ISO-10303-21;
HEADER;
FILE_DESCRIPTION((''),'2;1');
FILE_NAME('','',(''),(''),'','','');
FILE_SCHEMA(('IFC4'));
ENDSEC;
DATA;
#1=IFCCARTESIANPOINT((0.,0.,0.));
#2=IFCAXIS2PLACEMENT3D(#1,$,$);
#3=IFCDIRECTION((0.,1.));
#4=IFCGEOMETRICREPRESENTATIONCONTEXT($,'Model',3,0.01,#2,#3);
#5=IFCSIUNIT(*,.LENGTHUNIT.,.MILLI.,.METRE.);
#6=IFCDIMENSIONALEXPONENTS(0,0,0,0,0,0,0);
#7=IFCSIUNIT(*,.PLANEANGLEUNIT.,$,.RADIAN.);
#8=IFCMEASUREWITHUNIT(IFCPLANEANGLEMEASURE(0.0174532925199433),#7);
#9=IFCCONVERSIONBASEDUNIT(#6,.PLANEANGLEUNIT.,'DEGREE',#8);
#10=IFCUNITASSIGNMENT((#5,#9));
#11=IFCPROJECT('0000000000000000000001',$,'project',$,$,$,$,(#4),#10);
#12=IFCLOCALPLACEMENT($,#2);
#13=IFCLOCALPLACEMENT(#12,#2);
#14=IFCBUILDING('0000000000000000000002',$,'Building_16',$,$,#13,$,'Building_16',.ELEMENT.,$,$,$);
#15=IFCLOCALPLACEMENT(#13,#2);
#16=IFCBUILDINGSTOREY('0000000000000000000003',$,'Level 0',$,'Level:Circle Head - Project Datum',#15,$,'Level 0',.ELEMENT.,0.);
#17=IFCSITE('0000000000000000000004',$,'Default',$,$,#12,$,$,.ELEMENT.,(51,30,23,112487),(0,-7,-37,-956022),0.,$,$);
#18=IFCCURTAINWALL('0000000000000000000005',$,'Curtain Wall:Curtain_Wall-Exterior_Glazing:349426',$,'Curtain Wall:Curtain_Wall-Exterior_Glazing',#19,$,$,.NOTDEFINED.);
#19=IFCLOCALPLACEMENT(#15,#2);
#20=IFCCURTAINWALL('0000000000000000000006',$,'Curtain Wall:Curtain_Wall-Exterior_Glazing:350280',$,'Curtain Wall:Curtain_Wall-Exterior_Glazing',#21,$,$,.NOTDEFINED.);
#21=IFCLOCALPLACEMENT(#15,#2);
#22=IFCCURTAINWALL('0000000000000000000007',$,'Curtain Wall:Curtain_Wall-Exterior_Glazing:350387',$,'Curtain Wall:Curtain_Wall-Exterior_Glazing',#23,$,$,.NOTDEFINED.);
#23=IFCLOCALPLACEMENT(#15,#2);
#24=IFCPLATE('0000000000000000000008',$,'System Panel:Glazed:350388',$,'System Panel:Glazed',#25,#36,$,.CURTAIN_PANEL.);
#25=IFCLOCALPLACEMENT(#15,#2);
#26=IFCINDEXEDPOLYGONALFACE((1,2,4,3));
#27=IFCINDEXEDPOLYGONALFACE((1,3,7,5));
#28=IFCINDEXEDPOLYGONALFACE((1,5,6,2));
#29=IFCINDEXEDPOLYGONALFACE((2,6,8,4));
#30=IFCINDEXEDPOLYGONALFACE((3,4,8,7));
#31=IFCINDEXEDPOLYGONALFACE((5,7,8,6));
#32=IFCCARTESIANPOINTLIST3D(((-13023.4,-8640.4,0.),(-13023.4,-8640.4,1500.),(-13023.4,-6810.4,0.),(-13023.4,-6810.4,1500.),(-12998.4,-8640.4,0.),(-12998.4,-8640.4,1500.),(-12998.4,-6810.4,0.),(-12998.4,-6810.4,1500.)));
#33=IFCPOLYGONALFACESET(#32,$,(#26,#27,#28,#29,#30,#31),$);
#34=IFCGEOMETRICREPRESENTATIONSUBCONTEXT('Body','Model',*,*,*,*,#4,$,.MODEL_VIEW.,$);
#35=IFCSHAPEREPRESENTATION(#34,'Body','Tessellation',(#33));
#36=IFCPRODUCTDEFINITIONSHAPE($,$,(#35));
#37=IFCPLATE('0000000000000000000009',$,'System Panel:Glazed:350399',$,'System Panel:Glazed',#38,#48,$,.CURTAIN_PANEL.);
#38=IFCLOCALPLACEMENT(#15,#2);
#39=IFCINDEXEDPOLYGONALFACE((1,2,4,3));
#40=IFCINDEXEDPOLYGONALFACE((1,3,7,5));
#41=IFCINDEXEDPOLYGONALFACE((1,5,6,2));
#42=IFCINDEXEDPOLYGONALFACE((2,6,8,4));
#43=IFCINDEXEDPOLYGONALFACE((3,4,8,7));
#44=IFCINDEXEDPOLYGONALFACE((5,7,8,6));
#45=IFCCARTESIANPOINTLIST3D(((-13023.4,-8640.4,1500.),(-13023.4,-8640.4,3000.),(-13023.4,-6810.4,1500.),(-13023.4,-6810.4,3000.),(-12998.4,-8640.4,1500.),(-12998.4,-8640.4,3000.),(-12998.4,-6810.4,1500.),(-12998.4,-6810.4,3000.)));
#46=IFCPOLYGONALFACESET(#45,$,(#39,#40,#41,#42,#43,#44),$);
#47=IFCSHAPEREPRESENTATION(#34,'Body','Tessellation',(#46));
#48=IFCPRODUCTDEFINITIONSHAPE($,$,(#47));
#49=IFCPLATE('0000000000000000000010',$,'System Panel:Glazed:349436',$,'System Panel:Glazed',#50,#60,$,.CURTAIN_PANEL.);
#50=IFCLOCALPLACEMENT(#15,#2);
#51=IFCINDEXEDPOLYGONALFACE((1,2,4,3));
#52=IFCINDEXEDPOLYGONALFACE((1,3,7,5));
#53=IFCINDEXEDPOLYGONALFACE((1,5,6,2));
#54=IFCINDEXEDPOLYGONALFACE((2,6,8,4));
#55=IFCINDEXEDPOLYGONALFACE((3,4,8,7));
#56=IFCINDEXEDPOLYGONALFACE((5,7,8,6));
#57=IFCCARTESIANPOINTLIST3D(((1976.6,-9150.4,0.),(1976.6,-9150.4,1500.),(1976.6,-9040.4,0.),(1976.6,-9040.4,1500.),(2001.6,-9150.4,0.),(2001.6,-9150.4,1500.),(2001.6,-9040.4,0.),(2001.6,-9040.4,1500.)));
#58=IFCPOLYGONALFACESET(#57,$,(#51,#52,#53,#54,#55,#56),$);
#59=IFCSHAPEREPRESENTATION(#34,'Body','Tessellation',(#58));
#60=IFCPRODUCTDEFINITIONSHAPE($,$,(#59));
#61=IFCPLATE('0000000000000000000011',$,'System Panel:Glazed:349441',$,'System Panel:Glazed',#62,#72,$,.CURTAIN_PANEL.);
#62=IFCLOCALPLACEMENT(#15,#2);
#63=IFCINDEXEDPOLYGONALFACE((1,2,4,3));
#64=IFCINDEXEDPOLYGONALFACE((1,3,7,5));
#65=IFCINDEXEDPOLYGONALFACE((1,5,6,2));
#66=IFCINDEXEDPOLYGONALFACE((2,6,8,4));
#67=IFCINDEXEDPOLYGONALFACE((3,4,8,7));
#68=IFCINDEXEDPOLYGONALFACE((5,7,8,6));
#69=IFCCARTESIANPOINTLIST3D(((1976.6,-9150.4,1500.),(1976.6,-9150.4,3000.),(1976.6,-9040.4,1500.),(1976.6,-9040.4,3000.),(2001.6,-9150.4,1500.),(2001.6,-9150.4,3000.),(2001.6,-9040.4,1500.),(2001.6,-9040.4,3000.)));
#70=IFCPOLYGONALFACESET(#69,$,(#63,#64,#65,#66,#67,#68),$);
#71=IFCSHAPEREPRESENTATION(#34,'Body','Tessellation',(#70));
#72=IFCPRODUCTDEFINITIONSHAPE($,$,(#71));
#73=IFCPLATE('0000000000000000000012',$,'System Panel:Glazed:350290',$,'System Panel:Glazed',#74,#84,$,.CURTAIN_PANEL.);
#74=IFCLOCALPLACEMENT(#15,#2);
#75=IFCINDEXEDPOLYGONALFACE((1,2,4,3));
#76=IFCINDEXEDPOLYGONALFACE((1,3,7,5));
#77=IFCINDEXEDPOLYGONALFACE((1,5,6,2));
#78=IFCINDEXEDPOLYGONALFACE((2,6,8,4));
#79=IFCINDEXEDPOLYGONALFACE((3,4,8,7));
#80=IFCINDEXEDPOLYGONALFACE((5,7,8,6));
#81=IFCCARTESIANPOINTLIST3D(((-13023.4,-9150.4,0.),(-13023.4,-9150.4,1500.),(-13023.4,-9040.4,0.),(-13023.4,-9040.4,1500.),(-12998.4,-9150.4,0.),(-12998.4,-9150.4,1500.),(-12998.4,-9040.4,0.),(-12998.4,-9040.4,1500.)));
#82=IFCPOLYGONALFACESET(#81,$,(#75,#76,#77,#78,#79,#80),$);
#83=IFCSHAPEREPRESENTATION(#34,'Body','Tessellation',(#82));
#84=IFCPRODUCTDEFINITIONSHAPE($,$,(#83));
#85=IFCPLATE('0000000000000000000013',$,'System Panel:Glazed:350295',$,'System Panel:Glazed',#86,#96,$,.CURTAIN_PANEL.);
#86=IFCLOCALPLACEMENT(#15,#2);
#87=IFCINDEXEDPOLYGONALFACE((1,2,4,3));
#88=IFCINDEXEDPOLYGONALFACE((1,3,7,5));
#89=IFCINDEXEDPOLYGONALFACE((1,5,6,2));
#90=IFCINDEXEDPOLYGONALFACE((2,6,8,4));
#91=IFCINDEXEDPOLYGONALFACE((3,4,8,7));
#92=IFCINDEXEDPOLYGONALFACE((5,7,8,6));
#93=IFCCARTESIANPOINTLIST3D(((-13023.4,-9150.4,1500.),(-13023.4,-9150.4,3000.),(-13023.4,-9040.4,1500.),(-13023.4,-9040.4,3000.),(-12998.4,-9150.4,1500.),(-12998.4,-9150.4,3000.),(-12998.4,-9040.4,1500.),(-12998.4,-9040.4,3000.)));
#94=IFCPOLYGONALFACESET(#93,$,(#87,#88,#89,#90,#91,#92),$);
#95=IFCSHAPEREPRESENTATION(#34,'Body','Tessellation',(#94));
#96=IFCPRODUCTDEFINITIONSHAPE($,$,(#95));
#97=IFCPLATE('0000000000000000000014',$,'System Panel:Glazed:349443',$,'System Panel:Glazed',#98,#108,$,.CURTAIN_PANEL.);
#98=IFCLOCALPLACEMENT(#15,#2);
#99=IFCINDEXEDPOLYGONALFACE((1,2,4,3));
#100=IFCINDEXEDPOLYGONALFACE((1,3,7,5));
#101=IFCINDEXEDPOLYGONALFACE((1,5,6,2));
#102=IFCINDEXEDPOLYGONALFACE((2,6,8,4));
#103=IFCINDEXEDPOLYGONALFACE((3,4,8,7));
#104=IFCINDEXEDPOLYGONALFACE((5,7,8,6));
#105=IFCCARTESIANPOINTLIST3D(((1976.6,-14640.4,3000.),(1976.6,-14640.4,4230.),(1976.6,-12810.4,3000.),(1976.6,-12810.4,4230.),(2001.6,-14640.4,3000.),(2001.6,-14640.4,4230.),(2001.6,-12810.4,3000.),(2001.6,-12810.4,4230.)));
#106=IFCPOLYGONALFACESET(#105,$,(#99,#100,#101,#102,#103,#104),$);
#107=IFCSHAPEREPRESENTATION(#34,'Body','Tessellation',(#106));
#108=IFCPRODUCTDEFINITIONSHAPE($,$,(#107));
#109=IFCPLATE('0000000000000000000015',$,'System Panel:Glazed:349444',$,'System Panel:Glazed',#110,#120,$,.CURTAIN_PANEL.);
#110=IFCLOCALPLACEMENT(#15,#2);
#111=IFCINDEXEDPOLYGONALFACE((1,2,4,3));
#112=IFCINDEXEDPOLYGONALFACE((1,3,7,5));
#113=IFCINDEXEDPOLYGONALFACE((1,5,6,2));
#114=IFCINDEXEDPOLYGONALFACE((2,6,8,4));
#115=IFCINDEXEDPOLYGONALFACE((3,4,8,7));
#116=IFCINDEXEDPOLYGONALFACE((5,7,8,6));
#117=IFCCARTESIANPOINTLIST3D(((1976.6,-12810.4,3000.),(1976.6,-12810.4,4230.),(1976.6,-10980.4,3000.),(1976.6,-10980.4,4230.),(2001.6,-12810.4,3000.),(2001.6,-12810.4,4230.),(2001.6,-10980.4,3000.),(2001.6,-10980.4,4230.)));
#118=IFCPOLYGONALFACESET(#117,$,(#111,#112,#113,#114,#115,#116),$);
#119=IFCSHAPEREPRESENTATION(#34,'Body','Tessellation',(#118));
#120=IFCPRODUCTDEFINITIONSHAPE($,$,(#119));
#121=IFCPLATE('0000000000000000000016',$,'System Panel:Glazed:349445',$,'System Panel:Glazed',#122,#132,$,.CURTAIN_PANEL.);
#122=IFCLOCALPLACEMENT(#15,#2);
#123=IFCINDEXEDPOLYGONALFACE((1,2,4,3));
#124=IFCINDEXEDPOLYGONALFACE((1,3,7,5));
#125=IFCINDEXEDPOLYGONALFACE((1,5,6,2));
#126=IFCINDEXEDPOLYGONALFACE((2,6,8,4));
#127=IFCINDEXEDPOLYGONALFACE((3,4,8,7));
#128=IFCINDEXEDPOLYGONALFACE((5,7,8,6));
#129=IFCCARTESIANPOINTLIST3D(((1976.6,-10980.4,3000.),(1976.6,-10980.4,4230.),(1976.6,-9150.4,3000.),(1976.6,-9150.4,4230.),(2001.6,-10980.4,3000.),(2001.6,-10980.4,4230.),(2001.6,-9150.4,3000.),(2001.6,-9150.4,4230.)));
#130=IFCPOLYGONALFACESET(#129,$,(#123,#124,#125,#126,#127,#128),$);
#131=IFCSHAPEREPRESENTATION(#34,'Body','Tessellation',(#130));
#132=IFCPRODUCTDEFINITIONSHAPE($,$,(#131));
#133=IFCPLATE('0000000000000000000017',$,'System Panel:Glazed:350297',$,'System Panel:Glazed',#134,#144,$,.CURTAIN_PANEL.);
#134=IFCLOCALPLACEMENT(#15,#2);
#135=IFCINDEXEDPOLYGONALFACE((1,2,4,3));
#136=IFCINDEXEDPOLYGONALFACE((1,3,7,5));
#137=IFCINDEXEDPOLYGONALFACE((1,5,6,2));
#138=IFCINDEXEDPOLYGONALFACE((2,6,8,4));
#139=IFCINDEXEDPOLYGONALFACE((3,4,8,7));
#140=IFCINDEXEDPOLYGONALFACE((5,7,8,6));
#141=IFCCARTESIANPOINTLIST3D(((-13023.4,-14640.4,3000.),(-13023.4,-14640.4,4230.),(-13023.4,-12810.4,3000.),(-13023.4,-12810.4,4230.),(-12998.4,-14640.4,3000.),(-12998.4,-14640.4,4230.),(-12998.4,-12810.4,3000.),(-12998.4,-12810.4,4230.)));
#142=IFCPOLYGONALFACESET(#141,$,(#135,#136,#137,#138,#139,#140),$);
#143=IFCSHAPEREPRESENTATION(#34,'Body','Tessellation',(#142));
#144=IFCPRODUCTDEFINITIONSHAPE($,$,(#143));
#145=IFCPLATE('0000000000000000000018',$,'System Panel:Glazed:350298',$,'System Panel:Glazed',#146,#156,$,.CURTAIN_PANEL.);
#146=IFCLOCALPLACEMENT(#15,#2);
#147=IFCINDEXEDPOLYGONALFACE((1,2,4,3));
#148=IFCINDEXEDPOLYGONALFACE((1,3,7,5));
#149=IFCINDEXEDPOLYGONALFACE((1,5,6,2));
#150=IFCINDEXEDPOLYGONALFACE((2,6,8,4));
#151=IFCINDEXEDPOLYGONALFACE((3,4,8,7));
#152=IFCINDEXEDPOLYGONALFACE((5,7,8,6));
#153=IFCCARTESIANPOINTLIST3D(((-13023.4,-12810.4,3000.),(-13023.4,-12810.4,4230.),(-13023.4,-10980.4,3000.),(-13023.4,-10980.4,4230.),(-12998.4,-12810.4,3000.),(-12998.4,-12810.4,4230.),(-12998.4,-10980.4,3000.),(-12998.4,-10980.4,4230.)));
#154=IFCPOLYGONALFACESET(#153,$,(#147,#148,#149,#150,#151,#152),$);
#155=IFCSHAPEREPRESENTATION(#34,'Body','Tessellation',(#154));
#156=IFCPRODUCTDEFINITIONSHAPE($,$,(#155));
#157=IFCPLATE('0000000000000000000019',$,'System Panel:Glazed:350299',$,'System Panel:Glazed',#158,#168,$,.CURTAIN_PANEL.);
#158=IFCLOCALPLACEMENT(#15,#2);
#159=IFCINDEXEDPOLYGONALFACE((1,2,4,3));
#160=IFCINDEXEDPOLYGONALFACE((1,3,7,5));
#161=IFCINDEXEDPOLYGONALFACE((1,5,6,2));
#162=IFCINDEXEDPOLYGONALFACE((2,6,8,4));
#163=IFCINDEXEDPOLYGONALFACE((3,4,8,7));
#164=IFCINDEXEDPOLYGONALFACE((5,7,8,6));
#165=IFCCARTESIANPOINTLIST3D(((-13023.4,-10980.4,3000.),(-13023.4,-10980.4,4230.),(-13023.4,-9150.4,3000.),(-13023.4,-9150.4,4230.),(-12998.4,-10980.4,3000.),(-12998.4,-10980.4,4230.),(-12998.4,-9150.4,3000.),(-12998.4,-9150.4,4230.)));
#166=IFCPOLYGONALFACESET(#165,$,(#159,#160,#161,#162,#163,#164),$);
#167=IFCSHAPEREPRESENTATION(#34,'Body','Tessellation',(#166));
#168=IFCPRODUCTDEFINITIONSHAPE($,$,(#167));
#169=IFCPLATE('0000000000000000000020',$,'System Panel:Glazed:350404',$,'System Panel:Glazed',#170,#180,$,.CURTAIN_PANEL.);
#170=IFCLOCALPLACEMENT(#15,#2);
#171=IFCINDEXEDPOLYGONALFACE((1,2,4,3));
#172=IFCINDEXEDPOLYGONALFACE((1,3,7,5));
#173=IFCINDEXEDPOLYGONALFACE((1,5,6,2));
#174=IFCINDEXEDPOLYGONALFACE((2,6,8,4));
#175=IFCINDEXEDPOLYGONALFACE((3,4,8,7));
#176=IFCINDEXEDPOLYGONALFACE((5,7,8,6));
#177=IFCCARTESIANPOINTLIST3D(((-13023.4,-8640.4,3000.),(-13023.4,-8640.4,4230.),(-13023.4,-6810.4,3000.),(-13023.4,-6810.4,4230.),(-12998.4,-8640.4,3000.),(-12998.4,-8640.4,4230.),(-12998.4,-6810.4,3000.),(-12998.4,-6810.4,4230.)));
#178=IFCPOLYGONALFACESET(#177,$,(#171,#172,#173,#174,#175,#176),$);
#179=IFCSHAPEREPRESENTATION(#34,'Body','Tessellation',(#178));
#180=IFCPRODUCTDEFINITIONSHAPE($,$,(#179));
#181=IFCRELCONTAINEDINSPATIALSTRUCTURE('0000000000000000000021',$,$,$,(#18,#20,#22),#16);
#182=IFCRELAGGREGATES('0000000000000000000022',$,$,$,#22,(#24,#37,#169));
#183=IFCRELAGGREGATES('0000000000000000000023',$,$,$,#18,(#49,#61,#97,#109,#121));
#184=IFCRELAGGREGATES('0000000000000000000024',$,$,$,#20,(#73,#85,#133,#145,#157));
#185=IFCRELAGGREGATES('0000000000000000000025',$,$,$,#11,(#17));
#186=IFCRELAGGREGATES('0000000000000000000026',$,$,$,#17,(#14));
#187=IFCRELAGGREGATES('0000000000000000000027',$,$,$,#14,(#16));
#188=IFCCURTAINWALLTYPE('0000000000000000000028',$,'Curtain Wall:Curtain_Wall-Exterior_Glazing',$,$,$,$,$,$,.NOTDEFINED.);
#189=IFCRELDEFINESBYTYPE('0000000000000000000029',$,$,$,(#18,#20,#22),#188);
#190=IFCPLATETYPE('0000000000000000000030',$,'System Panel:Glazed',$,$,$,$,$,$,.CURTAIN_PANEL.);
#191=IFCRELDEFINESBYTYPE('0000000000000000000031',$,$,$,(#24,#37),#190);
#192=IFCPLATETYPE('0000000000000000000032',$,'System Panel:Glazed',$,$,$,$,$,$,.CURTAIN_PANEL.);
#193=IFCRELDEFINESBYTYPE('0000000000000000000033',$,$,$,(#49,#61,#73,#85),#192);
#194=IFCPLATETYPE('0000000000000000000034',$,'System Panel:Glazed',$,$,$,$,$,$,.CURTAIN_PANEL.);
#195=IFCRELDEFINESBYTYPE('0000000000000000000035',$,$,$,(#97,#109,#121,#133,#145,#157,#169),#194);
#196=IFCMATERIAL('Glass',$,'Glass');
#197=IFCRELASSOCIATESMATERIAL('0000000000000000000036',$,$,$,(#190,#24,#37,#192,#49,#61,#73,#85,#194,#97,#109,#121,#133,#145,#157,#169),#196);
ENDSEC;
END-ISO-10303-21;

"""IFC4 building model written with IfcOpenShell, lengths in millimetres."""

from ifc_helpers import new_model, entity, si_unit, converted_unit, direction, frame, origin, place, context, subcontext, project, spatial, indexed_curve, outline, extrude, source, transform, mapped, material, type_object, type_shapes, element, aggregate, save


model = new_model("IFC4")

# Units and contexts
model_context = context("Model", 3, precision=0.01, world=origin(), true_north=direction((0.0, 1.0)))
body_context = subcontext(model_context, "Body", "Model", "MODEL_VIEW")
ifc_project = project(units=[si_unit("LENGTHUNIT", "METRE", prefix="MILLI"), converted_unit("PLANEANGLEUNIT", "DEGREE", entity("IfcPlaneAngleMeasure", 0.0174532925199433), si_unit("PLANEANGLEUNIT", "RADIAN"), dimensions=[0, 0, 0, 0, 0, 0, 0])], contexts=[model_context])

# Site, building, storey
site_placement = place(None, origin())
site = spatial("IfcSite", under=ifc_project, at=site_placement, Name="Default", CompositionType="ELEMENT", RefLatitude=(51, 30, 23, 112487), RefLongitude=(0, -7, -37, -956022), RefElevation=0.0)
building_placement = place(site_placement, origin())
building = spatial("IfcBuilding", under=site, at=building_placement, Name="Building_16", LongName="Building_16", CompositionType="ELEMENT")
storey_placement = place(building_placement, origin())
storey = spatial("IfcBuildingStorey", under=building, at=storey_placement, Name="Level 0", ObjectType="Level:Circle Head - Project Datum", LongName="Level 0", CompositionType="ELEMENT", Elevation=0.0)

# Curtain walls, plates
curtain_wall_type = type_object("IfcCurtainWallType", Name="Curtain Wall:Curtain_Wall-Exterior_Glazing", PredefinedType="NOTDEFINED")
curtain_wall_1_placement = place(storey_placement, origin())
curtain_wall_1 = element("IfcCurtainWall", 1, at=curtain_wall_1_placement, inside=storey, type_object=curtain_wall_type, Name="Curtain Wall:Curtain_Wall-Exterior_Glazing:349426", ObjectType="Curtain Wall:Curtain_Wall-Exterior_Glazing", PredefinedType="NOTDEFINED")
ifc_material_1 = material(Name="Glass", Category="Glass")
plate_type_1 = type_object("IfcPlateType", Name="System Panel:Glazed", PredefinedType="CURTAIN_PANEL", material=ifc_material_1)
shared_shape_1 = source(origin(), body_context, "Body", "SweptSolid", [
    extrude(outline(indexed_curve([(-12.5, -915.0), (12.5, -915.0), (12.5, 915.0), (-12.5, 915.0), (-12.5, -915.0)], self_intersect=False)), frame((0.0, 37.0, 0.0), z_axis=(0.0, 0.0, 1.0), x_axis=(0.0, 1.0, 0.0)), (0.0, 0.0, 1.0), 1500.0),
])
type_shapes(plate_type_1, [shared_shape_1])
curtain_wall_2_placement = place(storey_placement, origin())
curtain_wall_2 = element("IfcCurtainWall", 2, at=curtain_wall_2_placement, inside=storey, type_object=curtain_wall_type, Name="Curtain Wall:Curtain_Wall-Exterior_Glazing:350280", ObjectType="Curtain Wall:Curtain_Wall-Exterior_Glazing", PredefinedType="NOTDEFINED")
curtain_wall_3_placement = place(storey_placement, origin())
curtain_wall_3 = element("IfcCurtainWall", 3, at=curtain_wall_3_placement, inside=storey, type_object=curtain_wall_type, Name="Curtain Wall:Curtain_Wall-Exterior_Glazing:350387", ObjectType="Curtain Wall:Curtain_Wall-Exterior_Glazing", PredefinedType="NOTDEFINED")
plate_1_placement = place(curtain_wall_3_placement, frame((-12973.9, -7725.4, 0.0), z_axis=(0.0, 0.0, 1.0), x_axis=(0.0, 1.0, 0.0)))
plate_1 = element("IfcPlate", 4, at=plate_1_placement, type_object=plate_type_1, material=ifc_material_1, Name="System Panel:Glazed:350388", ObjectType="System Panel:Glazed", PredefinedType="CURTAIN_PANEL", context=body_context, shape_type="MappedRepresentation", body=[
    mapped(shared_shape_1, transform((0.0, 0.0, 0.0), scale=1.0)),
])
plate_2_placement = place(curtain_wall_3_placement, frame((-12973.9, -7725.4, 1500.0), z_axis=(0.0, 0.0, 1.0), x_axis=(0.0, 1.0, 0.0)))
plate_2 = element("IfcPlate", 5, at=plate_2_placement, type_object=plate_type_1, material=ifc_material_1, Name="System Panel:Glazed:350399", ObjectType="System Panel:Glazed", PredefinedType="CURTAIN_PANEL", context=body_context, shape_type="MappedRepresentation", body=[
    mapped(shared_shape_1, transform((0.0, 0.0, 0.0), scale=1.0)),
])

# Plates
plate_type_2 = type_object("IfcPlateType", Name="System Panel:Glazed", PredefinedType="CURTAIN_PANEL", material=ifc_material_1)
shared_shape_2 = source(origin(), body_context, "Body", "SweptSolid", [
    extrude(outline(indexed_curve([(-12.5, -55.0), (12.5, -55.0), (12.5, 55.0), (-12.5, 55.0), (-12.5, -55.0)], self_intersect=False)), frame((0.0, 37.0, 0.0), z_axis=(0.0, 0.0, 1.0), x_axis=(0.0, 1.0, 0.0)), (0.0, 0.0, 1.0), 1500.0),
])
type_shapes(plate_type_2, [shared_shape_2])
plate_3_placement = place(curtain_wall_1_placement, frame((2026.1, -9095.4, 0.0), z_axis=(0.0, 0.0, 1.0), x_axis=(0.0, 1.0, 0.0)))
plate_3 = element("IfcPlate", 6, at=plate_3_placement, type_object=plate_type_2, material=ifc_material_1, Name="System Panel:Glazed:349436", ObjectType="System Panel:Glazed", PredefinedType="CURTAIN_PANEL", context=body_context, shape_type="MappedRepresentation", body=[
    mapped(shared_shape_2, transform((0.0, 0.0, 0.0), scale=1.0)),
])
plate_4_placement = place(curtain_wall_1_placement, frame((2026.1, -9095.4, 1500.0), z_axis=(0.0, 0.0, 1.0), x_axis=(0.0, 1.0, 0.0)))
plate_4 = element("IfcPlate", 7, at=plate_4_placement, type_object=plate_type_2, material=ifc_material_1, Name="System Panel:Glazed:349441", ObjectType="System Panel:Glazed", PredefinedType="CURTAIN_PANEL", context=body_context, shape_type="MappedRepresentation", body=[
    mapped(shared_shape_2, transform((0.0, 0.0, 0.0), scale=1.0)),
])
plate_5_placement = place(curtain_wall_2_placement, frame((-12973.9, -9095.4, 0.0), z_axis=(0.0, 0.0, 1.0), x_axis=(0.0, 1.0, 0.0)))
plate_5 = element("IfcPlate", 8, at=plate_5_placement, type_object=plate_type_2, material=ifc_material_1, Name="System Panel:Glazed:350290", ObjectType="System Panel:Glazed", PredefinedType="CURTAIN_PANEL", context=body_context, shape_type="MappedRepresentation", body=[
    mapped(shared_shape_2, transform((0.0, 0.0, 0.0), scale=1.0)),
])
plate_6_placement = place(curtain_wall_2_placement, frame((-12973.9, -9095.4, 1500.0), z_axis=(0.0, 0.0, 1.0), x_axis=(0.0, 1.0, 0.0)))
plate_6 = element("IfcPlate", 9, at=plate_6_placement, type_object=plate_type_2, material=ifc_material_1, Name="System Panel:Glazed:350295", ObjectType="System Panel:Glazed", PredefinedType="CURTAIN_PANEL", context=body_context, shape_type="MappedRepresentation", body=[
    mapped(shared_shape_2, transform((0.0, 0.0, 0.0), scale=1.0)),
])
plate_type_3 = type_object("IfcPlateType", Name="System Panel:Glazed", PredefinedType="CURTAIN_PANEL", material=ifc_material_1)
shared_shape_3 = source(origin(), body_context, "Body", "SweptSolid", [
    extrude(outline(indexed_curve([(-12.5, -915.0), (12.5, -915.0), (12.5, 915.0), (-12.5, 915.0), (-12.5, -915.0)], self_intersect=False)), frame((0.0, 37.0, 0.0), z_axis=(0.0, 0.0, 1.0), x_axis=(0.0, 1.0, 0.0)), (0.0, 0.0, 1.0), 1230.0),
])
type_shapes(plate_type_3, [shared_shape_3])
plate_7_placement = place(curtain_wall_1_placement, frame((2026.1, -13725.4, 3000.0), z_axis=(0.0, 0.0, 1.0), x_axis=(0.0, 1.0, 0.0)))
plate_7 = element("IfcPlate", 10, at=plate_7_placement, type_object=plate_type_3, material=ifc_material_1, Name="System Panel:Glazed:349443", ObjectType="System Panel:Glazed", PredefinedType="CURTAIN_PANEL", context=body_context, shape_type="MappedRepresentation", body=[
    mapped(shared_shape_3, transform((0.0, 0.0, 0.0), scale=1.0)),
])
plate_8_placement = place(curtain_wall_1_placement, frame((2026.1, -11895.4, 3000.0), z_axis=(0.0, 0.0, 1.0), x_axis=(0.0, 1.0, 0.0)))
plate_8 = element("IfcPlate", 11, at=plate_8_placement, type_object=plate_type_3, material=ifc_material_1, Name="System Panel:Glazed:349444", ObjectType="System Panel:Glazed", PredefinedType="CURTAIN_PANEL", context=body_context, shape_type="MappedRepresentation", body=[
    mapped(shared_shape_3, transform((0.0, 0.0, 0.0), scale=1.0)),
])
plate_9_placement = place(curtain_wall_1_placement, frame((2026.1, -10065.4, 3000.0), z_axis=(0.0, 0.0, 1.0), x_axis=(0.0, 1.0, 0.0)))
plate_9 = element("IfcPlate", 12, at=plate_9_placement, type_object=plate_type_3, material=ifc_material_1, Name="System Panel:Glazed:349445", ObjectType="System Panel:Glazed", PredefinedType="CURTAIN_PANEL", context=body_context, shape_type="MappedRepresentation", body=[
    mapped(shared_shape_3, transform((0.0, 0.0, 0.0), scale=1.0)),
])
plate_10_placement = place(curtain_wall_2_placement, frame((-12973.9, -13725.4, 3000.0), z_axis=(0.0, 0.0, 1.0), x_axis=(0.0, 1.0, 0.0)))
plate_10 = element("IfcPlate", 13, at=plate_10_placement, type_object=plate_type_3, material=ifc_material_1, Name="System Panel:Glazed:350297", ObjectType="System Panel:Glazed", PredefinedType="CURTAIN_PANEL", context=body_context, shape_type="MappedRepresentation", body=[
    mapped(shared_shape_3, transform((0.0, 0.0, 0.0), scale=1.0)),
])
plate_11_placement = place(curtain_wall_2_placement, frame((-12973.9, -11895.4, 3000.0), z_axis=(0.0, 0.0, 1.0), x_axis=(0.0, 1.0, 0.0)))
plate_11 = element("IfcPlate", 14, at=plate_11_placement, type_object=plate_type_3, material=ifc_material_1, Name="System Panel:Glazed:350298", ObjectType="System Panel:Glazed", PredefinedType="CURTAIN_PANEL", context=body_context, shape_type="MappedRepresentation", body=[
    mapped(shared_shape_3, transform((0.0, 0.0, 0.0), scale=1.0)),
])
plate_12_placement = place(curtain_wall_2_placement, frame((-12973.9, -10065.4, 3000.0), z_axis=(0.0, 0.0, 1.0), x_axis=(0.0, 1.0, 0.0)))
plate_12 = element("IfcPlate", 15, at=plate_12_placement, type_object=plate_type_3, material=ifc_material_1, Name="System Panel:Glazed:350299", ObjectType="System Panel:Glazed", PredefinedType="CURTAIN_PANEL", context=body_context, shape_type="MappedRepresentation", body=[
    mapped(shared_shape_3, transform((0.0, 0.0, 0.0), scale=1.0)),
])
plate_13_placement = place(curtain_wall_3_placement, frame((-12973.9, -7725.4, 3000.0), z_axis=(0.0, 0.0, 1.0), x_axis=(0.0, 1.0, 0.0)))
plate_13 = element("IfcPlate", 16, at=plate_13_placement, type_object=plate_type_3, material=ifc_material_1, Name="System Panel:Glazed:350404", ObjectType="System Panel:Glazed", PredefinedType="CURTAIN_PANEL", context=body_context, shape_type="MappedRepresentation", body=[
    mapped(shared_shape_3, transform((0.0, 0.0, 0.0), scale=1.0)),
])
aggregate(curtain_wall_3, [plate_1, plate_2, plate_13])
aggregate(curtain_wall_1, [plate_3, plate_4, plate_7, plate_8, plate_9])
aggregate(curtain_wall_2, [plate_5, plate_6, plate_10, plate_11, plate_12])

save(model, "model.ifc")
